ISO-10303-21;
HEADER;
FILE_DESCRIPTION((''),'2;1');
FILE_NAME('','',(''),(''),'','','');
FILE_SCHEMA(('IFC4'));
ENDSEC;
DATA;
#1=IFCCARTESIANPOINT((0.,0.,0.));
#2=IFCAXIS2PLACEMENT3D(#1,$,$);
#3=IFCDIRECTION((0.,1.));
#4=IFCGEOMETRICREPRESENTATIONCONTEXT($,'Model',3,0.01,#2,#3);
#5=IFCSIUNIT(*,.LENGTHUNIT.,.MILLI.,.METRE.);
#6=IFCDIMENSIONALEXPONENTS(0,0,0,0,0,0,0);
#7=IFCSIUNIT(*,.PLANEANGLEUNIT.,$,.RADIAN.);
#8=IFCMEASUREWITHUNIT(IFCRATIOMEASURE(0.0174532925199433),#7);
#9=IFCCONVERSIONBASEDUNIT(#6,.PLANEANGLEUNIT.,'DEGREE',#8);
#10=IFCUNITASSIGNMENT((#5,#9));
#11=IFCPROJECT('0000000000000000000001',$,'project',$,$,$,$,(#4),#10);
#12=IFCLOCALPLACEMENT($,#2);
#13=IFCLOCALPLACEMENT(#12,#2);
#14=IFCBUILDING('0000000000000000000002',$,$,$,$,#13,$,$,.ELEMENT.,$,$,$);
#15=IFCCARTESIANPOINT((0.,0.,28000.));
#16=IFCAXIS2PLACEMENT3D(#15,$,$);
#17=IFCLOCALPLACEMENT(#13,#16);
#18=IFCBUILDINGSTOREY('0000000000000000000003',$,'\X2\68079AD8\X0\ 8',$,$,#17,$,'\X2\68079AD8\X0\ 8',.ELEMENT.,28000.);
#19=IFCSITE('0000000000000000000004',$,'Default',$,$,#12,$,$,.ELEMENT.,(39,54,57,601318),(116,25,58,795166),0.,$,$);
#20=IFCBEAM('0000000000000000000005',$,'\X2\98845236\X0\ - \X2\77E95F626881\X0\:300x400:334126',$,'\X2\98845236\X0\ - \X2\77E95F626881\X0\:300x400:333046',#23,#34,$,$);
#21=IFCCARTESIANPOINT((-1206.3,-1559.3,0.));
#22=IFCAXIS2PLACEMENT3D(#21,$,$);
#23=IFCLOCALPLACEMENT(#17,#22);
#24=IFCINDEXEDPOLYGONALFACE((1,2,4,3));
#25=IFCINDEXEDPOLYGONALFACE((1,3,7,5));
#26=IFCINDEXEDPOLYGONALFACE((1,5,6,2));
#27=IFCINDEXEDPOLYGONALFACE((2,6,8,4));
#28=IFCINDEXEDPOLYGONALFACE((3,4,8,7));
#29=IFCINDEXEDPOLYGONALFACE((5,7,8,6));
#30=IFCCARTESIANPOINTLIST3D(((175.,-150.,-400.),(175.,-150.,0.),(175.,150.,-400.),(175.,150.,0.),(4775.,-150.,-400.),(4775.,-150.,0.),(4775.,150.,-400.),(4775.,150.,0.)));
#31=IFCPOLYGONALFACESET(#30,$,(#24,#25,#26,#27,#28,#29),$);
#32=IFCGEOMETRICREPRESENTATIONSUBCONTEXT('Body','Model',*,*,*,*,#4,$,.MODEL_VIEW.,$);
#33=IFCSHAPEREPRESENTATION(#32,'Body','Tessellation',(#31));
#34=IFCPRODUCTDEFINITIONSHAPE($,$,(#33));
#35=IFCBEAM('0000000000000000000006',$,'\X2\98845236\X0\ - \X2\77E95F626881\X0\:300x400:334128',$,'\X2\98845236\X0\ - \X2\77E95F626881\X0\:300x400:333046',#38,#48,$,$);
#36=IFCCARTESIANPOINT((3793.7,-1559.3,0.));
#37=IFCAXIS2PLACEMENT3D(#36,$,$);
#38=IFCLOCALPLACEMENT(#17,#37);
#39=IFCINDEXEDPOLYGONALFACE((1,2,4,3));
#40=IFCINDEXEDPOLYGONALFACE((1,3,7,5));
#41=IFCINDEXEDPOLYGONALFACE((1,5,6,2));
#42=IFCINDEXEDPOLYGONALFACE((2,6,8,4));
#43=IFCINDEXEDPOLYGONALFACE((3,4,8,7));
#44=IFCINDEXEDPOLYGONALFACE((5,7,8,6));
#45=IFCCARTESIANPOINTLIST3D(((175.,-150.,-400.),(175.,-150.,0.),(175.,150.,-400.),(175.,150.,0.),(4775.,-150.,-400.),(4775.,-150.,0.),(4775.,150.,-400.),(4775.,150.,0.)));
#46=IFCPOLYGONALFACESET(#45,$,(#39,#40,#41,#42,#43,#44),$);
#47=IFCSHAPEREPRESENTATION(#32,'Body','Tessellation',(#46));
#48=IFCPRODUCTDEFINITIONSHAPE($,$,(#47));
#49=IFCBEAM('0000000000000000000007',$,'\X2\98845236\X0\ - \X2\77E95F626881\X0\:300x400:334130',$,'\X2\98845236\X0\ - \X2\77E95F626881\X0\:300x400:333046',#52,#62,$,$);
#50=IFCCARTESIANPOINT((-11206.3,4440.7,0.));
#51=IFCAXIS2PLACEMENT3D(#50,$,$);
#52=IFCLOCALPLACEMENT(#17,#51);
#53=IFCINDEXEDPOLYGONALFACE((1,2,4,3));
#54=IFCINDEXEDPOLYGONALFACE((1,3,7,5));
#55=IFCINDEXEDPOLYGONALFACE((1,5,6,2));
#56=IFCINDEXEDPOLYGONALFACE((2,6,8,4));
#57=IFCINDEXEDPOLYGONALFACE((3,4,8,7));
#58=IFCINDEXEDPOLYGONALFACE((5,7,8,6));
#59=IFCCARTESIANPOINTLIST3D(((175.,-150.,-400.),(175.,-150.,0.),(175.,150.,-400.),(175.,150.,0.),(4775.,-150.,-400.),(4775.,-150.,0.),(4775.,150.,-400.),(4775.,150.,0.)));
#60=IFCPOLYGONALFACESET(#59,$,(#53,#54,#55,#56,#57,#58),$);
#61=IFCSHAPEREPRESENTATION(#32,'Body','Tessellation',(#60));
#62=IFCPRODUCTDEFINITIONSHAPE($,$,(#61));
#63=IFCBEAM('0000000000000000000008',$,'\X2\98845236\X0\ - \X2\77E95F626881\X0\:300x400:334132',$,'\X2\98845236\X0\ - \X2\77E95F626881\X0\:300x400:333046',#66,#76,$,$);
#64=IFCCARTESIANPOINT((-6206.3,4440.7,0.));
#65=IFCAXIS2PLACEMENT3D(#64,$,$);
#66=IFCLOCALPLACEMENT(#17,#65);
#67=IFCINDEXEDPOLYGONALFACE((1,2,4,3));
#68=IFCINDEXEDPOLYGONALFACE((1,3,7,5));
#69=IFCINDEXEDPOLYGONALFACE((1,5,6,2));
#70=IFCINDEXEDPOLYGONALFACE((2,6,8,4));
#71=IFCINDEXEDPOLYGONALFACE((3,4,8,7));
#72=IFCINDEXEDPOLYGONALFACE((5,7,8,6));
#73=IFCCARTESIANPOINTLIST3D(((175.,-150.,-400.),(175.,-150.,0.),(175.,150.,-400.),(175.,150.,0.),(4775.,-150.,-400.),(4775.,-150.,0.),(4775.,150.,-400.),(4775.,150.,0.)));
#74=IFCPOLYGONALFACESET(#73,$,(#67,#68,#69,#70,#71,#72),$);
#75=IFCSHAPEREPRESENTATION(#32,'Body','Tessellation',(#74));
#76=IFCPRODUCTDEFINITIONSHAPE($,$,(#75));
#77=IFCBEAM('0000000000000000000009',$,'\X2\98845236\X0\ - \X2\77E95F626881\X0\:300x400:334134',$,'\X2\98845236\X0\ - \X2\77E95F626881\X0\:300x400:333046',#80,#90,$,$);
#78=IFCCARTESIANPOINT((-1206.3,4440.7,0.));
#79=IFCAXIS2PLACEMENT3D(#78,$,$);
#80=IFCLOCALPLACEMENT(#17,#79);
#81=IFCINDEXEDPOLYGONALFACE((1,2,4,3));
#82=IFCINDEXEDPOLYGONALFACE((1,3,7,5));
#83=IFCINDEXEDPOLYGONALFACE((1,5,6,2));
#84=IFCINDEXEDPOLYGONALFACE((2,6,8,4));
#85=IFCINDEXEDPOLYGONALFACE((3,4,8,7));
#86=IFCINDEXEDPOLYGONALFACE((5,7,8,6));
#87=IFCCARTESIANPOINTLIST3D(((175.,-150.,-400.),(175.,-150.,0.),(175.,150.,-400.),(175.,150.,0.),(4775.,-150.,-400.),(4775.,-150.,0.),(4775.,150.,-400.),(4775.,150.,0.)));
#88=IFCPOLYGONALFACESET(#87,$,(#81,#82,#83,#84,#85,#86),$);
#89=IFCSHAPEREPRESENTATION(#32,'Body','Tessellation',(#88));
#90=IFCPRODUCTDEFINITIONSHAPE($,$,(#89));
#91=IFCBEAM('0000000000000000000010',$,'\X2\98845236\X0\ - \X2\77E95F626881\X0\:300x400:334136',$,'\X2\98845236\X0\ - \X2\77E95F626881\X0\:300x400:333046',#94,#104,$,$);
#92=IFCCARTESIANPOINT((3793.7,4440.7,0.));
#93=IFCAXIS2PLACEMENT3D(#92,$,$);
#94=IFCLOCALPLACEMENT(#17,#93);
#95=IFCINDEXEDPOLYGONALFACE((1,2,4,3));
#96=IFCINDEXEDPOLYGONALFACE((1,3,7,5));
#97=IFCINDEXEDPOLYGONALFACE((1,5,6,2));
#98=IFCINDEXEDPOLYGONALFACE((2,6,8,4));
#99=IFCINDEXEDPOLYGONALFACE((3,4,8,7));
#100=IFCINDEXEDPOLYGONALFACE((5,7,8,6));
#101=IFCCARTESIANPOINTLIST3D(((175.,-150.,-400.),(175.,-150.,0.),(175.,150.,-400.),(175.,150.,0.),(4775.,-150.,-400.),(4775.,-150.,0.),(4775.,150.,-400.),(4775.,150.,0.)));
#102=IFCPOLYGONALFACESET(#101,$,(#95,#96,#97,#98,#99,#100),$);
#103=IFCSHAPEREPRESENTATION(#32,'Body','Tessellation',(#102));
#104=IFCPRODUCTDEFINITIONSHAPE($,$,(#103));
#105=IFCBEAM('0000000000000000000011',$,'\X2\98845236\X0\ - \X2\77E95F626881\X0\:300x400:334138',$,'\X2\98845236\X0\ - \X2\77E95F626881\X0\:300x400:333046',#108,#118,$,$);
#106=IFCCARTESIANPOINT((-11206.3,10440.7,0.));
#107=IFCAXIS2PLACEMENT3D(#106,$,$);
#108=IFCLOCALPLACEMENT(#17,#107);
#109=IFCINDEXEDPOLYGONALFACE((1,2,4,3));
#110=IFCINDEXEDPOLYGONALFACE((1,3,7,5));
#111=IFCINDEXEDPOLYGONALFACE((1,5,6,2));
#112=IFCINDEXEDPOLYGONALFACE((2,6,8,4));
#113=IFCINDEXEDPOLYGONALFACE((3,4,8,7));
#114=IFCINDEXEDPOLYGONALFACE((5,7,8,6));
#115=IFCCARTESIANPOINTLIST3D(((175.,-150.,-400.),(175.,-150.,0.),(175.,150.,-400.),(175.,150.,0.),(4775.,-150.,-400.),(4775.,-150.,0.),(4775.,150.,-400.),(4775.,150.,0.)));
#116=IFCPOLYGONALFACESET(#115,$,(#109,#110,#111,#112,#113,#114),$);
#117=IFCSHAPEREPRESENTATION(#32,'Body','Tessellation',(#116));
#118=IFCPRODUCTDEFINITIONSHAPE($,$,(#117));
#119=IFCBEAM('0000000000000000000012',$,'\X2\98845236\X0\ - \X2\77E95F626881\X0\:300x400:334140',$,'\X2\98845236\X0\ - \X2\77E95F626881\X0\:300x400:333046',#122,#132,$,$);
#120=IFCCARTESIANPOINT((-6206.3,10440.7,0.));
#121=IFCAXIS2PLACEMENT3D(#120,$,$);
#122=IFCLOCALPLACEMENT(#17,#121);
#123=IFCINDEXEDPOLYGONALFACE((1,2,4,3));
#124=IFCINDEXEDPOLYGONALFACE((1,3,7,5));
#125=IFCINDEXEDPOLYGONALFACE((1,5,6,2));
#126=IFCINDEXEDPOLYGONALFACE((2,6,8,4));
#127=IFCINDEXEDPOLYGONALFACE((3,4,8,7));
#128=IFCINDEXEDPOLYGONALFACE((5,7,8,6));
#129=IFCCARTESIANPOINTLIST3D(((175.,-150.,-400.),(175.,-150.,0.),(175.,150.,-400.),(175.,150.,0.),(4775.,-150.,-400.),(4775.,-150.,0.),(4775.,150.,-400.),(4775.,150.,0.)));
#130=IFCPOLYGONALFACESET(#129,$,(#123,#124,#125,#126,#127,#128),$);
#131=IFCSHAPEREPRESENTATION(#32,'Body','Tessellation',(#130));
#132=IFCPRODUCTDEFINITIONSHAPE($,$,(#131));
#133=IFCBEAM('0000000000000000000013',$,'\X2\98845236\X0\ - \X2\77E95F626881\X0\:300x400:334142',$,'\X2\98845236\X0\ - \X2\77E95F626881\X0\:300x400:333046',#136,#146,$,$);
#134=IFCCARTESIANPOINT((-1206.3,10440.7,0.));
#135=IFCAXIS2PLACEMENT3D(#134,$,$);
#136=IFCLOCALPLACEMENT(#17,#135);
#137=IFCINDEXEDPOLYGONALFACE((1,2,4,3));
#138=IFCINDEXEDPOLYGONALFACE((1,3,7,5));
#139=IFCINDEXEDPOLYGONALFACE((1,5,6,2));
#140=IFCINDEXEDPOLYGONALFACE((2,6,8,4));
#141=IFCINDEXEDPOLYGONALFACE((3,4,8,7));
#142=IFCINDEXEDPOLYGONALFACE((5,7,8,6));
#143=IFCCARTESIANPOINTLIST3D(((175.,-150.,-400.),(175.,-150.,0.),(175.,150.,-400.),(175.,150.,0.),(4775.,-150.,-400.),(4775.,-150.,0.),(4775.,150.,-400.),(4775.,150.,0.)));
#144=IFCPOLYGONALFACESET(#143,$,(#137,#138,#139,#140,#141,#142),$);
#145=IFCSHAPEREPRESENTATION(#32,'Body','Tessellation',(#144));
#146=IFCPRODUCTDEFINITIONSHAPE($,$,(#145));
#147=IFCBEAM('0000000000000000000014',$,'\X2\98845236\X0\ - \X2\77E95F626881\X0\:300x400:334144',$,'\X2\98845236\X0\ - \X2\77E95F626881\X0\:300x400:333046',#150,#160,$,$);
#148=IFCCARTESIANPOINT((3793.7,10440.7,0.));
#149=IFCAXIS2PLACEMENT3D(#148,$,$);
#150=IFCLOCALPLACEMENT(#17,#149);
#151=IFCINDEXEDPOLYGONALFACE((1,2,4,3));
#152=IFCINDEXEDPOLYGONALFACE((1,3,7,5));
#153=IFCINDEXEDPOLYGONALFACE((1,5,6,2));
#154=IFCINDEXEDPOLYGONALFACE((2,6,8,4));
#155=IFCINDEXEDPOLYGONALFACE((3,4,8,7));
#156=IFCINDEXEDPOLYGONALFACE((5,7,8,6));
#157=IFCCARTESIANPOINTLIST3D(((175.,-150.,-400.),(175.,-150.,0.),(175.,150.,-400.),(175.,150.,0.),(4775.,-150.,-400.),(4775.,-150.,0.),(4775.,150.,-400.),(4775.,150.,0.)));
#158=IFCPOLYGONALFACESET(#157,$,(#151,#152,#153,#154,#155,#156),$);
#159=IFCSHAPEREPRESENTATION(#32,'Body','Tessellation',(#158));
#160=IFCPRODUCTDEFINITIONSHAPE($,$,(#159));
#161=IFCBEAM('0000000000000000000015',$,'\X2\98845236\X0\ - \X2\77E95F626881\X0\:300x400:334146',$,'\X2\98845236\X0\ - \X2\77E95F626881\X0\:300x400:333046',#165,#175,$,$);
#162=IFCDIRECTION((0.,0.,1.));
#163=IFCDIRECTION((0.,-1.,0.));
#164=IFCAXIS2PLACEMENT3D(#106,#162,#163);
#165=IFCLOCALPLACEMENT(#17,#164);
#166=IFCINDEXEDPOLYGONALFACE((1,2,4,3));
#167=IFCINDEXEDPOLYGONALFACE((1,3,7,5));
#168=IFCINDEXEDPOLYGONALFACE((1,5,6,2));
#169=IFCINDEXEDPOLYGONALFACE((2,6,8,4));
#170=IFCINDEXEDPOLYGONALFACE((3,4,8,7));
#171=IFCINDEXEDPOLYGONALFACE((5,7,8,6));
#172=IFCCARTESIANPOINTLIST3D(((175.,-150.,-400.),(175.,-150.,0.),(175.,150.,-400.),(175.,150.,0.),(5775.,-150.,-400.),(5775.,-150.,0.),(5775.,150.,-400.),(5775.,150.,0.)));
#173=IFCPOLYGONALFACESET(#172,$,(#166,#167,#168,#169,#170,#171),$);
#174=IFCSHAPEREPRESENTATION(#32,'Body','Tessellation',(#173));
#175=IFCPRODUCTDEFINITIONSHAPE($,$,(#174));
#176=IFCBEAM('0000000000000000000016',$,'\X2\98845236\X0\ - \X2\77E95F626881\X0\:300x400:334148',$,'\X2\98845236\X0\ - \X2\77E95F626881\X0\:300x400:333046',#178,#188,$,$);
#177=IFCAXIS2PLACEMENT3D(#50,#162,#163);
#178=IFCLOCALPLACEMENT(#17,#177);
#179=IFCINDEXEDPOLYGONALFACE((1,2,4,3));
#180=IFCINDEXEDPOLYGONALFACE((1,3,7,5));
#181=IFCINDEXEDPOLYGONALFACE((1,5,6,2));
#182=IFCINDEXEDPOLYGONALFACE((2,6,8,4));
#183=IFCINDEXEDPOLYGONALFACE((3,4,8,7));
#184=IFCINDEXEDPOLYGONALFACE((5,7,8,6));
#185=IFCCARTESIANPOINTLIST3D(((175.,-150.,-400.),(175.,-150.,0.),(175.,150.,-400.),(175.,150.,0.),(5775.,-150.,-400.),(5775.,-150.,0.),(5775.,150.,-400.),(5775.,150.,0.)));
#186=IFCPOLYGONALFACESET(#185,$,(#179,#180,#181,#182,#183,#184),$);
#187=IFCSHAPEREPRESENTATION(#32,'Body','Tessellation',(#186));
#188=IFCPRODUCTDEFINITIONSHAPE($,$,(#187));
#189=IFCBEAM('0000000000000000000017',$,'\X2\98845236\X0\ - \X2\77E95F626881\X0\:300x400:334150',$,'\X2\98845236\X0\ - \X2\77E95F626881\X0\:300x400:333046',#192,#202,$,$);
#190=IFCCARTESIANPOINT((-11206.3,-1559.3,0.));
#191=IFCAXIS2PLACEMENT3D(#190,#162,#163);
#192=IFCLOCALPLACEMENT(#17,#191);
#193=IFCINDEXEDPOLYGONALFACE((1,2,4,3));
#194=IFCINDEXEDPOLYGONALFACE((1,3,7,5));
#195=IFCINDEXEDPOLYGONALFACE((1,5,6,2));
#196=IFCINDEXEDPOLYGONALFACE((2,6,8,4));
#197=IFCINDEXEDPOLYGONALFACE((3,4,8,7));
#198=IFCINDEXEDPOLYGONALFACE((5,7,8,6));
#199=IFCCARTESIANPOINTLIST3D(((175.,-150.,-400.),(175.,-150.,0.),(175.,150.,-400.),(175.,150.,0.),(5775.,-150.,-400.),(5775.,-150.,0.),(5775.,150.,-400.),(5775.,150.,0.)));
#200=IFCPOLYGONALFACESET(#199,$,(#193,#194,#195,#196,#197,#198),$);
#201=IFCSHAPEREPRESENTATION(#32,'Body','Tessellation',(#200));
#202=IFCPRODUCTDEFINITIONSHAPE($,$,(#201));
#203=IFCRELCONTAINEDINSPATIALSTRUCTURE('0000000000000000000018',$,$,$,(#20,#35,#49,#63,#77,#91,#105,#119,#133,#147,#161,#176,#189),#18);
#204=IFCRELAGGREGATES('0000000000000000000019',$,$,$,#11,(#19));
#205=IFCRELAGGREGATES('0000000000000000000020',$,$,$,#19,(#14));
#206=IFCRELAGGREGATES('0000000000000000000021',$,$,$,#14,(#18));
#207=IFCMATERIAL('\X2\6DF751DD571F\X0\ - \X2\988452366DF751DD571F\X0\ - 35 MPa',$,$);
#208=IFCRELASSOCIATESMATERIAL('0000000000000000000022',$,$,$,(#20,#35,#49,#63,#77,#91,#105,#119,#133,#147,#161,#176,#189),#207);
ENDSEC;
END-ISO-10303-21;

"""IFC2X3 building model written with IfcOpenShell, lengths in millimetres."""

from ifc_helpers import new_model, entity, si_unit, converted_unit, direction, frame, frame_2d, origin, origin_2d_with_axis, place, context, subcontext, project, spatial, rectangle, extrude, material, element, save


model = new_model("IFC2X3")

# Units and contexts
model_context = context("Model", 3, precision=0.01, world=origin(), true_north=direction((0.0, 1.0)))
body_context = subcontext(model_context, "Body", "Model", "MODEL_VIEW")
ifc_project = project(units=[si_unit("LENGTHUNIT", "METRE", prefix="MILLI"), converted_unit("PLANEANGLEUNIT", "DEGREE", entity("IfcRatioMeasure", 0.0174532925199433), si_unit("PLANEANGLEUNIT", "RADIAN"), dimensions=[0, 0, 0, 0, 0, 0, 0])], contexts=[model_context])

# Site, building, storey
site_placement = place(None, origin())
site = spatial("IfcSite", under=ifc_project, at=site_placement, Name="Default", CompositionType="ELEMENT", RefLatitude=(39, 54, 57, 601318), RefLongitude=(116, 25, 58, 795166), RefElevation=0.0)
building_placement = place(site_placement, origin())
building = spatial("IfcBuilding", under=site, at=building_placement, CompositionType="ELEMENT")
storey_placement = place(building_placement, frame((0.0, 0.0, 28000.0)))
storey = spatial("IfcBuildingStorey", under=building, at=storey_placement, Name="标高 8", LongName="标高 8", CompositionType="ELEMENT", Elevation=28000.0)

# Beams
ifc_material_1 = material(Name="混凝土 - 预制混凝土 - 35 MPa")
beam_1_placement = place(storey_placement, frame((-1206.3, -1559.3, 0.0)))
element("IfcBeam", 1, at=beam_1_placement, inside=storey, material=ifc_material_1, Name="预制 - 矩形梁:300x400:334126", ObjectType="预制 - 矩形梁:300x400:333046", context=body_context, shape_type="SweptSolid", body=[
    extrude(rectangle(XDim=400.0, YDim=300.0, at=frame_2d((0.0, 0.0), x_axis=(1.0, 0.0))), frame((175.0, 0.0, -200.0), z_axis=(1.0, 0.0, 0.0), x_axis=(0.0, 0.0, -1.0)), (0.0, 0.0, 1.0), 4600.0),
])
beam_2_placement = place(storey_placement, frame((3793.7, -1559.3, 0.0)))
element("IfcBeam", 2, at=beam_2_placement, inside=storey, material=ifc_material_1, Name="预制 - 矩形梁:300x400:334128", ObjectType="预制 - 矩形梁:300x400:333046", context=body_context, shape_type="SweptSolid", body=[
    extrude(rectangle(XDim=400.0, YDim=300.0, at=frame_2d((0.0, 0.0), x_axis=(1.0, 0.0))), frame((175.0, 0.0, -200.0), z_axis=(1.0, 0.0, 0.0), x_axis=(0.0, 0.0, -1.0)), (0.0, 0.0, 1.0), 4600.0),
])
beam_3_placement = place(storey_placement, frame((-11206.3, 4440.7, 0.0)))
element("IfcBeam", 3, at=beam_3_placement, inside=storey, material=ifc_material_1, Name="预制 - 矩形梁:300x400:334130", ObjectType="预制 - 矩形梁:300x400:333046", context=body_context, shape_type="SweptSolid", body=[
    extrude(rectangle(XDim=400.0, YDim=300.0, at=frame_2d((0.0, 0.0), x_axis=(1.0, 0.0))), frame((175.0, 0.0, -200.0), z_axis=(1.0, 0.0, 0.0), x_axis=(0.0, 0.0, -1.0)), (0.0, 0.0, 1.0), 4600.0),
])
beam_4_placement = place(storey_placement, frame((-6206.3, 4440.7, 0.0)))
element("IfcBeam", 4, at=beam_4_placement, inside=storey, material=ifc_material_1, Name="预制 - 矩形梁:300x400:334132", ObjectType="预制 - 矩形梁:300x400:333046", context=body_context, shape_type="SweptSolid", body=[
    extrude(rectangle(XDim=400.0, YDim=300.0, at=frame_2d((0.0, 0.0), x_axis=(1.0, 0.0))), frame((175.0, 0.0, -200.0), z_axis=(1.0, 0.0, 0.0), x_axis=(0.0, 0.0, -1.0)), (0.0, 0.0, 1.0), 4600.0),
])
beam_5_placement = place(storey_placement, frame((-1206.3, 4440.7, 0.0)))
element("IfcBeam", 5, at=beam_5_placement, inside=storey, material=ifc_material_1, Name="预制 - 矩形梁:300x400:334134", ObjectType="预制 - 矩形梁:300x400:333046", context=body_context, shape_type="SweptSolid", body=[
    extrude(rectangle(XDim=400.0, YDim=300.0, at=frame_2d((0.0, 0.0), x_axis=(1.0, 0.0))), frame((175.0, 0.0, -200.0), z_axis=(1.0, 0.0, 0.0), x_axis=(0.0, 0.0, -1.0)), (0.0, 0.0, 1.0), 4600.0),
])
beam_6_placement = place(storey_placement, frame((3793.7, 4440.7, 0.0)))
element("IfcBeam", 6, at=beam_6_placement, inside=storey, material=ifc_material_1, Name="预制 - 矩形梁:300x400:334136", ObjectType="预制 - 矩形梁:300x400:333046", context=body_context, shape_type="SweptSolid", body=[
    extrude(rectangle(XDim=400.0, YDim=300.0, at=frame_2d((0.0, 0.0), x_axis=(1.0, 0.0))), frame((175.0, 0.0, -200.0), z_axis=(1.0, 0.0, 0.0), x_axis=(0.0, 0.0, -1.0)), (0.0, 0.0, 1.0), 4600.0),
])
beam_7_placement = place(storey_placement, frame((-11206.3, 10440.7, 0.0)))
element("IfcBeam", 7, at=beam_7_placement, inside=storey, material=ifc_material_1, Name="预制 - 矩形梁:300x400:334138", ObjectType="预制 - 矩形梁:300x400:333046", context=body_context, shape_type="SweptSolid", body=[
    extrude(rectangle(XDim=400.0, YDim=300.0, at=frame_2d((0.0, 0.0), x_axis=(1.0, 0.0))), frame((175.0, 0.0, -200.0), z_axis=(1.0, 0.0, 0.0), x_axis=(0.0, 0.0, -1.0)), (0.0, 0.0, 1.0), 4600.0),
])
beam_8_placement = place(storey_placement, frame((-6206.3, 10440.7, 0.0)))
element("IfcBeam", 8, at=beam_8_placement, inside=storey, material=ifc_material_1, Name="预制 - 矩形梁:300x400:334140", ObjectType="预制 - 矩形梁:300x400:333046", context=body_context, shape_type="SweptSolid", body=[
    extrude(rectangle(XDim=400.0, YDim=300.0, at=frame_2d((0.0, 0.0), x_axis=(1.0, 0.0))), frame((175.0, 0.0, -200.0), z_axis=(1.0, 0.0, 0.0), x_axis=(0.0, 0.0, -1.0)), (0.0, 0.0, 1.0), 4600.0),
])
beam_9_placement = place(storey_placement, frame((-1206.3, 10440.7, 0.0)))
element("IfcBeam", 9, at=beam_9_placement, inside=storey, material=ifc_material_1, Name="预制 - 矩形梁:300x400:334142", ObjectType="预制 - 矩形梁:300x400:333046", context=body_context, shape_type="SweptSolid", body=[
    extrude(rectangle(XDim=400.0, YDim=300.0, at=frame_2d((0.0, 0.0), x_axis=(1.0, 0.0))), frame((175.0, 0.0, -200.0), z_axis=(1.0, 0.0, 0.0), x_axis=(0.0, 0.0, -1.0)), (0.0, 0.0, 1.0), 4600.0),
])
beam_10_placement = place(storey_placement, frame((3793.7, 10440.7, 0.0)))
element("IfcBeam", 10, at=beam_10_placement, inside=storey, material=ifc_material_1, Name="预制 - 矩形梁:300x400:334144", ObjectType="预制 - 矩形梁:300x400:333046", context=body_context, shape_type="SweptSolid", body=[
    extrude(rectangle(XDim=400.0, YDim=300.0, at=frame_2d((0.0, 0.0), x_axis=(1.0, 0.0))), frame((175.0, 0.0, -200.0), z_axis=(1.0, 0.0, 0.0), x_axis=(0.0, 0.0, -1.0)), (0.0, 0.0, 1.0), 4600.0),
])
for number, where, z_axis, x_axis, name in (
    (11, (-11206.3, 10440.7, 0.0), (0.0, 0.0, 1.0), (0.0, -1.0, 0.0), "预制 - 矩形梁:300x400:334146"),
    (12, (-11206.3, 4440.7, 0.0), (0.0, 0.0, 1.0), (0.0, -1.0, 0.0), "预制 - 矩形梁:300x400:334148"),
):
    element("IfcBeam", number, at=place(storey_placement, frame(where, z_axis=z_axis, x_axis=x_axis)), inside=storey, material=ifc_material_1, Name=name, ObjectType="预制 - 矩形梁:300x400:333046", context=body_context, shape_type="SweptSolid", body=[
        extrude(rectangle(XDim=400.0, YDim=300.0, at=origin_2d_with_axis()), frame((175.0, 0.0, -200.0), z_axis=(1.0, 0.0, 0.0), x_axis=(0.0, 0.0, -1.0)), (0.0, 0.0, 1.0), 5600.0),
    ])
beam_11_placement = place(storey_placement, frame((-11206.3, -1559.3, 0.0), z_axis=(0.0, 0.0, 1.0), x_axis=(0.0, -1.0, 0.0)))
element("IfcBeam", 13, at=beam_11_placement, inside=storey, material=ifc_material_1, Name="预制 - 矩形梁:300x400:334150", ObjectType="预制 - 矩形梁:300x400:333046", context=body_context, shape_type="SweptSolid", body=[
    extrude(rectangle(XDim=400.0, YDim=300.0, at=frame_2d((0.0, 0.0), x_axis=(1.0, 0.0))), frame((175.0, 0.0, -200.0), z_axis=(1.0, 0.0, 0.0), x_axis=(0.0, 0.0, -1.0)), (0.0, 0.0, 1.0), 5600.0),
])

save(model, "model.ifc")
